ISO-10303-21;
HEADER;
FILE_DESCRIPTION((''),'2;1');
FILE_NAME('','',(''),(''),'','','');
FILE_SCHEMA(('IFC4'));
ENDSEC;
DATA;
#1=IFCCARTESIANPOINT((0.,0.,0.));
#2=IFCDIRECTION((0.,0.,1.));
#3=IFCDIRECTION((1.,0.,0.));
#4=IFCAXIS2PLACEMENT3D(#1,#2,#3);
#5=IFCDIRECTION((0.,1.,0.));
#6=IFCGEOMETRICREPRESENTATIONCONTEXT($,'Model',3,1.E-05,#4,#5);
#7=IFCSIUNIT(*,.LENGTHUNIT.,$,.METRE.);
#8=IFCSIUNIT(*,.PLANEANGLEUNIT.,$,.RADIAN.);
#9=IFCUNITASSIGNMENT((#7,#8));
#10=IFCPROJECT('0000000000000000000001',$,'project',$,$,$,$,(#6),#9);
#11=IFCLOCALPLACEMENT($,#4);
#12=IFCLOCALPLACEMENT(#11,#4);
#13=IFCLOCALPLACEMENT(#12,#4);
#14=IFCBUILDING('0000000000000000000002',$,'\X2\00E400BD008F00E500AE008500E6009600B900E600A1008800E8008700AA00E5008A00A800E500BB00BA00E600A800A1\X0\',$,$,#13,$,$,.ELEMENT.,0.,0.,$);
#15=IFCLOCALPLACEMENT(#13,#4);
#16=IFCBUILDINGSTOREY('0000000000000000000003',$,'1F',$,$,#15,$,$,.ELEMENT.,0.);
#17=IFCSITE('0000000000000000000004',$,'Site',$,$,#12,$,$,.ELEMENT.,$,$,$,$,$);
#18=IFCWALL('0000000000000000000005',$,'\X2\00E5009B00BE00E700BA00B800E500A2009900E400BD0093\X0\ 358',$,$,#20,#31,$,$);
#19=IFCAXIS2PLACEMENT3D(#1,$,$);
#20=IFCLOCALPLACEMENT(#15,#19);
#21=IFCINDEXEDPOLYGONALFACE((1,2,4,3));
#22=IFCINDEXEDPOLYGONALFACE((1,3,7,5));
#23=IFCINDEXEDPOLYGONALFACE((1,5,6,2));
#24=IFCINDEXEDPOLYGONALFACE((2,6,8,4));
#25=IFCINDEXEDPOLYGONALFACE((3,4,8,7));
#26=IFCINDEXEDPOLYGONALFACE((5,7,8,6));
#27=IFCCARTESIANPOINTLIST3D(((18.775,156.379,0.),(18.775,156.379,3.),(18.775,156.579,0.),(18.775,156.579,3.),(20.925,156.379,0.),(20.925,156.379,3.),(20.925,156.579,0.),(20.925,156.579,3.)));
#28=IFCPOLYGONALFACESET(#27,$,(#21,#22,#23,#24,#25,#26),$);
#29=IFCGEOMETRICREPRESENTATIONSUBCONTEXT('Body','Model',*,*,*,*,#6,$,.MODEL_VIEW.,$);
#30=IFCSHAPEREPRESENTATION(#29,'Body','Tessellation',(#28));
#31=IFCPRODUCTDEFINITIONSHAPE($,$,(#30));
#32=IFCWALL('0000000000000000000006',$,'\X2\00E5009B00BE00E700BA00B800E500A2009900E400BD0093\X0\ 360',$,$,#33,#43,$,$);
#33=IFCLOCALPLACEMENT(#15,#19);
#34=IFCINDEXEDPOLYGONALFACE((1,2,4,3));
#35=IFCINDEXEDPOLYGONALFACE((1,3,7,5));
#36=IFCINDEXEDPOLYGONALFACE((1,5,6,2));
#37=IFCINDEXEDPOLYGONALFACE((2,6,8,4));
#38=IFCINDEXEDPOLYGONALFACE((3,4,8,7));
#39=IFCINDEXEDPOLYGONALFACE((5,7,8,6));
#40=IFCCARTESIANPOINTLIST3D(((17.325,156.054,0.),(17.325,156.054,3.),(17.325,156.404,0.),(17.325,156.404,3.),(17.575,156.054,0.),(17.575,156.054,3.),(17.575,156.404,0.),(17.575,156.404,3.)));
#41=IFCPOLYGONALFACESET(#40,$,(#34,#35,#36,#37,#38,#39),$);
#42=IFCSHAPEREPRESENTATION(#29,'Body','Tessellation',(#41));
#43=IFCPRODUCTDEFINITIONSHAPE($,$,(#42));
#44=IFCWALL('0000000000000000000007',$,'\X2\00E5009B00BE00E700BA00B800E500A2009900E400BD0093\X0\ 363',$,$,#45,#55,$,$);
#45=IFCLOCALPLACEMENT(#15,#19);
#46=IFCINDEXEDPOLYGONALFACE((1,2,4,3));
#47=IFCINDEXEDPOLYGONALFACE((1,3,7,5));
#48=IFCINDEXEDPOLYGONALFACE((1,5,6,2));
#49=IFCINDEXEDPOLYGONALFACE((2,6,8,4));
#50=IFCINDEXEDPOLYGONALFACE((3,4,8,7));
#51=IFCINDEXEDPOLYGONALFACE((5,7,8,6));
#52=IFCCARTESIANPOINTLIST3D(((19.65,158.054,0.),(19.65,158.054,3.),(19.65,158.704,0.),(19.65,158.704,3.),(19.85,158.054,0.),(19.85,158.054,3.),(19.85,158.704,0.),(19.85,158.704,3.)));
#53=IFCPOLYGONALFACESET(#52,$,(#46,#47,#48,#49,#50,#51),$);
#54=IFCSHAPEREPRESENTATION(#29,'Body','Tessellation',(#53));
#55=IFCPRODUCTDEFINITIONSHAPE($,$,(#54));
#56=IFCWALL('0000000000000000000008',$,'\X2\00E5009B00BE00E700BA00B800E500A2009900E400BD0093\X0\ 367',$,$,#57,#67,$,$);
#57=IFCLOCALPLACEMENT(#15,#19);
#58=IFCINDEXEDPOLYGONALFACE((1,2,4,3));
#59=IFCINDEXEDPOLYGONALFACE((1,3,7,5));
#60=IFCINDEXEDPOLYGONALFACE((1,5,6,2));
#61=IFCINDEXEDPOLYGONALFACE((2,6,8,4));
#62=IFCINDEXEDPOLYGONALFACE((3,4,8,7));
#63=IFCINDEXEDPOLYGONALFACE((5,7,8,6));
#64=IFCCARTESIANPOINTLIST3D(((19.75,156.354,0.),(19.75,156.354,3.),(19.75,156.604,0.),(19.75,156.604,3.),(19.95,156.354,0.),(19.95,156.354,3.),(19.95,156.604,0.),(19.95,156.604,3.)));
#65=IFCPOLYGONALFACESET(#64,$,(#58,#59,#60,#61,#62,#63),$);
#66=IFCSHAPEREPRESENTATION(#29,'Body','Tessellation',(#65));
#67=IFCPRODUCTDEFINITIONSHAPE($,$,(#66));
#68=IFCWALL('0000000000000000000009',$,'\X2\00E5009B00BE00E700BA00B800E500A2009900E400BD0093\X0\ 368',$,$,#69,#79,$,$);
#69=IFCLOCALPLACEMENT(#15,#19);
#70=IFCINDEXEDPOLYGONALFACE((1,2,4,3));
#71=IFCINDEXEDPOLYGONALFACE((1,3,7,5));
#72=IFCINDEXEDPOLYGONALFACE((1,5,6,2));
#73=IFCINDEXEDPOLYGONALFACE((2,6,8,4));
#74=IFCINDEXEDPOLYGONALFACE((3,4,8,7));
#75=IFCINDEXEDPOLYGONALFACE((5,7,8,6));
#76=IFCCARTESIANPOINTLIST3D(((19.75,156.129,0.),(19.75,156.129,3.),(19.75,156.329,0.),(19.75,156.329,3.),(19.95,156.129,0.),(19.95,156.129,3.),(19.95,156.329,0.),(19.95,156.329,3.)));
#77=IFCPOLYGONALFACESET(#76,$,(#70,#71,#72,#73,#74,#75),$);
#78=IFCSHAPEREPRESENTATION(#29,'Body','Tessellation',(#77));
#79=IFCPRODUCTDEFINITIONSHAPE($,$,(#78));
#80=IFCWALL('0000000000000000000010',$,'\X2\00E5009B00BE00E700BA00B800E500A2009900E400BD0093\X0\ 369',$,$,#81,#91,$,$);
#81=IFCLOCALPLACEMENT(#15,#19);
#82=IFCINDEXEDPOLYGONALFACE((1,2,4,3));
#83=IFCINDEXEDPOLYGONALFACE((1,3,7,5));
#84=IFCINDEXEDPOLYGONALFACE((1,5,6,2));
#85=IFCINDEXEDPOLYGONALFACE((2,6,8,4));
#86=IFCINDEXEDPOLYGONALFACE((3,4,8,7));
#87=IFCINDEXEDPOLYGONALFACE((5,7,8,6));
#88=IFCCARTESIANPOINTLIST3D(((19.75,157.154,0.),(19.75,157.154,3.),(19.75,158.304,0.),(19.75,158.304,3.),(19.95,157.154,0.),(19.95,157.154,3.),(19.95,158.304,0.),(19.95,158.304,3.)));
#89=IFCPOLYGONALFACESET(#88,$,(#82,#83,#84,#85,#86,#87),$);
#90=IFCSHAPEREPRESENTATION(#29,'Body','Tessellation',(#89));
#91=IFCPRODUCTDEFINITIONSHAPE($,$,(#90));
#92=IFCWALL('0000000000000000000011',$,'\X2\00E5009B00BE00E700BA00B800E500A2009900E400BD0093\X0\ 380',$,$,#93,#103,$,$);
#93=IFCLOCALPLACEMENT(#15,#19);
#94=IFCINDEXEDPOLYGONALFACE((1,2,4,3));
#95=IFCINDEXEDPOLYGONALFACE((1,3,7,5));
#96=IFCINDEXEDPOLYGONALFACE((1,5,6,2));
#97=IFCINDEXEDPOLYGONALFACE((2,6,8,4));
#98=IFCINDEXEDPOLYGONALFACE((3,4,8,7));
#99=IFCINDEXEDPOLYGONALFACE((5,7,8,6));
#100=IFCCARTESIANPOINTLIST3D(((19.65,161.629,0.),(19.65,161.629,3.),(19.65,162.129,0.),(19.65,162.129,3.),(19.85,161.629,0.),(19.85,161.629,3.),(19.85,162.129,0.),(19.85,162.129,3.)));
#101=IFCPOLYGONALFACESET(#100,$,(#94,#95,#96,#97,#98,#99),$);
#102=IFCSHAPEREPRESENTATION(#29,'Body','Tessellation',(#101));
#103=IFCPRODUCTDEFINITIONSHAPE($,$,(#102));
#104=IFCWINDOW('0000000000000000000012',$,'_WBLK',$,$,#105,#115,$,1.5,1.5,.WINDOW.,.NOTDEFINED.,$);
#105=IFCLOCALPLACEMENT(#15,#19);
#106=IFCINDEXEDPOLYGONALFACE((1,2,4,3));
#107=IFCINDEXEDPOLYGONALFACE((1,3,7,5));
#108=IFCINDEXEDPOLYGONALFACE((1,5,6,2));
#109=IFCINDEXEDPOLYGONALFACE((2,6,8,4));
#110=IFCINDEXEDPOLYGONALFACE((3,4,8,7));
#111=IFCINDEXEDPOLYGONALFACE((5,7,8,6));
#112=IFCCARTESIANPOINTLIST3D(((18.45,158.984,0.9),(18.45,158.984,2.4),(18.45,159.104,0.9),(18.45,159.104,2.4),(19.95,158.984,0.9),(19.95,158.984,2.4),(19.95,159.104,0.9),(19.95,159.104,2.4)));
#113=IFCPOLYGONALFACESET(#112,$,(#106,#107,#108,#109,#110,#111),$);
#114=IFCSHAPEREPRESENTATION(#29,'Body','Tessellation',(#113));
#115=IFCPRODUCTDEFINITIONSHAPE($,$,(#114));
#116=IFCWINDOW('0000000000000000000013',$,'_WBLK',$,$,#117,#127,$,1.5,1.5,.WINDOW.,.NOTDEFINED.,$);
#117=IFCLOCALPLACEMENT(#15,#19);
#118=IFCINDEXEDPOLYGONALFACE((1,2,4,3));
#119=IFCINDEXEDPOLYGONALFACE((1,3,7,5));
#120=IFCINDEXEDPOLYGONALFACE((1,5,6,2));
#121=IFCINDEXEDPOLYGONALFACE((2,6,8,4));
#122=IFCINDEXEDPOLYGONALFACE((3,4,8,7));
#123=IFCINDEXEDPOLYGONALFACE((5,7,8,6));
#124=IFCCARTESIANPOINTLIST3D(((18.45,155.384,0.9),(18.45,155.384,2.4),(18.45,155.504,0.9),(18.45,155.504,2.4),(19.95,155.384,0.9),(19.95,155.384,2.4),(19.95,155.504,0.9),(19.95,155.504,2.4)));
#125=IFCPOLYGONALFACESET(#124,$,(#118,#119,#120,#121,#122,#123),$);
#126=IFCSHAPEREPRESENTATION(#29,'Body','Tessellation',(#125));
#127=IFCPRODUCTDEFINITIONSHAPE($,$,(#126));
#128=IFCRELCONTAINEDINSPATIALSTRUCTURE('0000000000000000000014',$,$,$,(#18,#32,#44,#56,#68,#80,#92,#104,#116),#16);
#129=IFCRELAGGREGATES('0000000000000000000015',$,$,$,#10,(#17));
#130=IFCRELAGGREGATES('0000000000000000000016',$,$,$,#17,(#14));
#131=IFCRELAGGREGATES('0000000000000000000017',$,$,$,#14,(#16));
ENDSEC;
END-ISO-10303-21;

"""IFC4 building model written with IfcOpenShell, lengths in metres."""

from ifc_helpers import new_model, si_unit, direction, frame, frame_2d, origin_with_axes, place, context, subcontext, project, spatial, rectangle, extrude, element, save


model = new_model("IFC4")

# Units and contexts
model_context = context("Model", 3, precision=1e-05, world=origin_with_axes(), true_north=direction((0.0, 1.0, 0.0)))
body_context = subcontext(model_context, "Body", "Model", "MODEL_VIEW")
ifc_project = project(units=[si_unit("LENGTHUNIT", "METRE"), si_unit("PLANEANGLEUNIT", "RADIAN")], contexts=[model_context])

# Site, building, storey
placement = place(None, origin_with_axes())
site_placement = place(placement, origin_with_axes())
site = spatial("IfcSite", under=ifc_project, at=site_placement, Name="Site", CompositionType="ELEMENT")
building_placement = place(site_placement, origin_with_axes())
building = spatial("IfcBuilding", under=site, at=building_placement, Name="ä½\u008få®\u0085æ\u0096¹æ¡\u0088è\u0087ªå\u008a¨å»ºæ¨¡", CompositionType="ELEMENT", ElevationOfRefHeight=0.0, ElevationOfTerrain=0.0)
storey_placement = place(building_placement, origin_with_axes())
storey = spatial("IfcBuildingStorey", under=building, at=storey_placement, Name="1F", CompositionType="ELEMENT", Elevation=0.0)

# Walls
wall_1_placement = place(storey_placement, frame((19.85, 156.479, 0.0), z_axis=(0.0, 0.0, 1.0), x_axis=(-1.0, 0.0, 0.0)))
element("IfcWall", 1, at=wall_1_placement, inside=storey, Name="å\u009b¾çº¸å¢\u0099ä½\u0093 358", context=body_context, shape_type="SweptSolid", body=[
    extrude(rectangle(XDim=2.15, YDim=0.2, at=frame_2d((0.0, 0.0), x_axis=(1.0, 0.0, 0.0))), frame((0.0, 0.0, 0.0), z_axis=(0.0, 0.0, 1.0)), (0.0, 0.0, 1.0), 3.0),
])
wall_2_placement = place(storey_placement, frame((17.45, 156.229, 0.0), z_axis=(0.0, 0.0, 1.0), x_axis=(1.0, 0.0, 0.0)))
element("IfcWall", 2, at=wall_2_placement, inside=storey, Name="å\u009b¾çº¸å¢\u0099ä½\u0093 360", context=body_context, shape_type="SweptSolid", body=[
    extrude(rectangle(XDim=0.25, YDim=0.35, at=frame_2d((0.0, 0.0), x_axis=(1.0, 0.0, 0.0))), frame((0.0, 0.0, 0.0), z_axis=(0.0, 0.0, 1.0)), (0.0, 0.0, 1.0), 3.0),
])
wall_3_placement = place(storey_placement, frame((19.75, 158.379, 0.0), z_axis=(0.0, 0.0, 1.0), x_axis=(0.0, -1.0, 0.0)))
element("IfcWall", 3, at=wall_3_placement, inside=storey, Name="å\u009b¾çº¸å¢\u0099ä½\u0093 363", context=body_context, shape_type="SweptSolid", body=[
    extrude(rectangle(XDim=0.65, YDim=0.2, at=frame_2d((0.0, 0.0), x_axis=(1.0, 0.0, 0.0))), frame((0.0, 0.0, 0.0), z_axis=(0.0, 0.0, 1.0)), (0.0, 0.0, 1.0), 3.0),
])
wall_4_placement = place(storey_placement, frame((19.85, 156.479, 0.0), z_axis=(0.0, 0.0, 1.0), x_axis=(0.0, -1.0, 0.0)))
element("IfcWall", 4, at=wall_4_placement, inside=storey, Name="å\u009b¾çº¸å¢\u0099ä½\u0093 367", context=body_context, shape_type="SweptSolid", body=[
    extrude(rectangle(XDim=0.25, YDim=0.2, at=frame_2d((0.0, 0.0), x_axis=(1.0, 0.0, 0.0))), frame((0.0, 0.0, 0.0), z_axis=(0.0, 0.0, 1.0)), (0.0, 0.0, 1.0), 3.0),
])
wall_5_placement = place(storey_placement, frame((19.85, 156.229, 0.0), z_axis=(0.0, 0.0, 1.0), x_axis=(1.0, 0.0, 0.0)))
element("IfcWall", 5, at=wall_5_placement, inside=storey, Name="å\u009b¾çº¸å¢\u0099ä½\u0093 368", context=body_context, shape_type="SweptSolid", body=[
    extrude(rectangle(XDim=0.2, YDim=0.2, at=frame_2d((0.0, 0.0), x_axis=(1.0, 0.0, 0.0))), frame((0.0, 0.0, 0.0), z_axis=(0.0, 0.0, 1.0)), (0.0, 0.0, 1.0), 3.0),
])
wall_6_placement = place(storey_placement, frame((19.85, 157.729, 0.0), z_axis=(0.0, 0.0, 1.0), x_axis=(0.0, -1.0, 0.0)))
element("IfcWall", 6, at=wall_6_placement, inside=storey, Name="å\u009b¾çº¸å¢\u0099ä½\u0093 369", context=body_context, shape_type="SweptSolid", body=[
    extrude(rectangle(XDim=1.15, YDim=0.2, at=frame_2d((0.0, 0.0), x_axis=(1.0, 0.0, 0.0))), frame((0.0, 0.0, 0.0), z_axis=(0.0, 0.0, 1.0)), (0.0, 0.0, 1.0), 3.0),
])
wall_7_placement = place(storey_placement, frame((19.75, 161.879, 0.0), z_axis=(0.0, 0.0, 1.0), x_axis=(0.0, -1.0, 0.0)))
element("IfcWall", 7, at=wall_7_placement, inside=storey, Name="å\u009b¾çº¸å¢\u0099ä½\u0093 380", context=body_context, shape_type="SweptSolid", body=[
    extrude(rectangle(XDim=0.5, YDim=0.2, at=frame_2d((0.0, 0.0), x_axis=(1.0, 0.0, 0.0))), frame((0.0, 0.0, 0.0), z_axis=(0.0, 0.0, 1.0)), (0.0, 0.0, 1.0), 3.0),
])

# Windows
for number, where, z_axis, x_axis, name in (
    (8, (19.2, 159.044, 0.9), (0.0, 0.0, 1.0), (1.0, 0.0, 0.0), "_WBLK"),
    (9, (19.2, 155.444, 0.9), (0.0, 0.0, 1.0), (1.0, 0.0, 0.0), "_WBLK"),
):
    element("IfcWindow", number, at=place(storey_placement, frame(where, z_axis=z_axis, x_axis=x_axis)), inside=storey, Name=name, OverallHeight=1.5, OverallWidth=1.5, PartitioningType="NOTDEFINED", PredefinedType="WINDOW", context=body_context, shape_type="SweptSolid", body=[
        extrude(rectangle(XDim=1.5, YDim=0.12, at=frame_2d((0.0, 0.0), x_axis=(1.0, 0.0, 0.0))), frame((0.0, 0.0, 0.0), z_axis=(0.0, 0.0, 1.0)), (0.0, 0.0, 1.0), 1.5),
    ])

save(model, "model.ifc")
